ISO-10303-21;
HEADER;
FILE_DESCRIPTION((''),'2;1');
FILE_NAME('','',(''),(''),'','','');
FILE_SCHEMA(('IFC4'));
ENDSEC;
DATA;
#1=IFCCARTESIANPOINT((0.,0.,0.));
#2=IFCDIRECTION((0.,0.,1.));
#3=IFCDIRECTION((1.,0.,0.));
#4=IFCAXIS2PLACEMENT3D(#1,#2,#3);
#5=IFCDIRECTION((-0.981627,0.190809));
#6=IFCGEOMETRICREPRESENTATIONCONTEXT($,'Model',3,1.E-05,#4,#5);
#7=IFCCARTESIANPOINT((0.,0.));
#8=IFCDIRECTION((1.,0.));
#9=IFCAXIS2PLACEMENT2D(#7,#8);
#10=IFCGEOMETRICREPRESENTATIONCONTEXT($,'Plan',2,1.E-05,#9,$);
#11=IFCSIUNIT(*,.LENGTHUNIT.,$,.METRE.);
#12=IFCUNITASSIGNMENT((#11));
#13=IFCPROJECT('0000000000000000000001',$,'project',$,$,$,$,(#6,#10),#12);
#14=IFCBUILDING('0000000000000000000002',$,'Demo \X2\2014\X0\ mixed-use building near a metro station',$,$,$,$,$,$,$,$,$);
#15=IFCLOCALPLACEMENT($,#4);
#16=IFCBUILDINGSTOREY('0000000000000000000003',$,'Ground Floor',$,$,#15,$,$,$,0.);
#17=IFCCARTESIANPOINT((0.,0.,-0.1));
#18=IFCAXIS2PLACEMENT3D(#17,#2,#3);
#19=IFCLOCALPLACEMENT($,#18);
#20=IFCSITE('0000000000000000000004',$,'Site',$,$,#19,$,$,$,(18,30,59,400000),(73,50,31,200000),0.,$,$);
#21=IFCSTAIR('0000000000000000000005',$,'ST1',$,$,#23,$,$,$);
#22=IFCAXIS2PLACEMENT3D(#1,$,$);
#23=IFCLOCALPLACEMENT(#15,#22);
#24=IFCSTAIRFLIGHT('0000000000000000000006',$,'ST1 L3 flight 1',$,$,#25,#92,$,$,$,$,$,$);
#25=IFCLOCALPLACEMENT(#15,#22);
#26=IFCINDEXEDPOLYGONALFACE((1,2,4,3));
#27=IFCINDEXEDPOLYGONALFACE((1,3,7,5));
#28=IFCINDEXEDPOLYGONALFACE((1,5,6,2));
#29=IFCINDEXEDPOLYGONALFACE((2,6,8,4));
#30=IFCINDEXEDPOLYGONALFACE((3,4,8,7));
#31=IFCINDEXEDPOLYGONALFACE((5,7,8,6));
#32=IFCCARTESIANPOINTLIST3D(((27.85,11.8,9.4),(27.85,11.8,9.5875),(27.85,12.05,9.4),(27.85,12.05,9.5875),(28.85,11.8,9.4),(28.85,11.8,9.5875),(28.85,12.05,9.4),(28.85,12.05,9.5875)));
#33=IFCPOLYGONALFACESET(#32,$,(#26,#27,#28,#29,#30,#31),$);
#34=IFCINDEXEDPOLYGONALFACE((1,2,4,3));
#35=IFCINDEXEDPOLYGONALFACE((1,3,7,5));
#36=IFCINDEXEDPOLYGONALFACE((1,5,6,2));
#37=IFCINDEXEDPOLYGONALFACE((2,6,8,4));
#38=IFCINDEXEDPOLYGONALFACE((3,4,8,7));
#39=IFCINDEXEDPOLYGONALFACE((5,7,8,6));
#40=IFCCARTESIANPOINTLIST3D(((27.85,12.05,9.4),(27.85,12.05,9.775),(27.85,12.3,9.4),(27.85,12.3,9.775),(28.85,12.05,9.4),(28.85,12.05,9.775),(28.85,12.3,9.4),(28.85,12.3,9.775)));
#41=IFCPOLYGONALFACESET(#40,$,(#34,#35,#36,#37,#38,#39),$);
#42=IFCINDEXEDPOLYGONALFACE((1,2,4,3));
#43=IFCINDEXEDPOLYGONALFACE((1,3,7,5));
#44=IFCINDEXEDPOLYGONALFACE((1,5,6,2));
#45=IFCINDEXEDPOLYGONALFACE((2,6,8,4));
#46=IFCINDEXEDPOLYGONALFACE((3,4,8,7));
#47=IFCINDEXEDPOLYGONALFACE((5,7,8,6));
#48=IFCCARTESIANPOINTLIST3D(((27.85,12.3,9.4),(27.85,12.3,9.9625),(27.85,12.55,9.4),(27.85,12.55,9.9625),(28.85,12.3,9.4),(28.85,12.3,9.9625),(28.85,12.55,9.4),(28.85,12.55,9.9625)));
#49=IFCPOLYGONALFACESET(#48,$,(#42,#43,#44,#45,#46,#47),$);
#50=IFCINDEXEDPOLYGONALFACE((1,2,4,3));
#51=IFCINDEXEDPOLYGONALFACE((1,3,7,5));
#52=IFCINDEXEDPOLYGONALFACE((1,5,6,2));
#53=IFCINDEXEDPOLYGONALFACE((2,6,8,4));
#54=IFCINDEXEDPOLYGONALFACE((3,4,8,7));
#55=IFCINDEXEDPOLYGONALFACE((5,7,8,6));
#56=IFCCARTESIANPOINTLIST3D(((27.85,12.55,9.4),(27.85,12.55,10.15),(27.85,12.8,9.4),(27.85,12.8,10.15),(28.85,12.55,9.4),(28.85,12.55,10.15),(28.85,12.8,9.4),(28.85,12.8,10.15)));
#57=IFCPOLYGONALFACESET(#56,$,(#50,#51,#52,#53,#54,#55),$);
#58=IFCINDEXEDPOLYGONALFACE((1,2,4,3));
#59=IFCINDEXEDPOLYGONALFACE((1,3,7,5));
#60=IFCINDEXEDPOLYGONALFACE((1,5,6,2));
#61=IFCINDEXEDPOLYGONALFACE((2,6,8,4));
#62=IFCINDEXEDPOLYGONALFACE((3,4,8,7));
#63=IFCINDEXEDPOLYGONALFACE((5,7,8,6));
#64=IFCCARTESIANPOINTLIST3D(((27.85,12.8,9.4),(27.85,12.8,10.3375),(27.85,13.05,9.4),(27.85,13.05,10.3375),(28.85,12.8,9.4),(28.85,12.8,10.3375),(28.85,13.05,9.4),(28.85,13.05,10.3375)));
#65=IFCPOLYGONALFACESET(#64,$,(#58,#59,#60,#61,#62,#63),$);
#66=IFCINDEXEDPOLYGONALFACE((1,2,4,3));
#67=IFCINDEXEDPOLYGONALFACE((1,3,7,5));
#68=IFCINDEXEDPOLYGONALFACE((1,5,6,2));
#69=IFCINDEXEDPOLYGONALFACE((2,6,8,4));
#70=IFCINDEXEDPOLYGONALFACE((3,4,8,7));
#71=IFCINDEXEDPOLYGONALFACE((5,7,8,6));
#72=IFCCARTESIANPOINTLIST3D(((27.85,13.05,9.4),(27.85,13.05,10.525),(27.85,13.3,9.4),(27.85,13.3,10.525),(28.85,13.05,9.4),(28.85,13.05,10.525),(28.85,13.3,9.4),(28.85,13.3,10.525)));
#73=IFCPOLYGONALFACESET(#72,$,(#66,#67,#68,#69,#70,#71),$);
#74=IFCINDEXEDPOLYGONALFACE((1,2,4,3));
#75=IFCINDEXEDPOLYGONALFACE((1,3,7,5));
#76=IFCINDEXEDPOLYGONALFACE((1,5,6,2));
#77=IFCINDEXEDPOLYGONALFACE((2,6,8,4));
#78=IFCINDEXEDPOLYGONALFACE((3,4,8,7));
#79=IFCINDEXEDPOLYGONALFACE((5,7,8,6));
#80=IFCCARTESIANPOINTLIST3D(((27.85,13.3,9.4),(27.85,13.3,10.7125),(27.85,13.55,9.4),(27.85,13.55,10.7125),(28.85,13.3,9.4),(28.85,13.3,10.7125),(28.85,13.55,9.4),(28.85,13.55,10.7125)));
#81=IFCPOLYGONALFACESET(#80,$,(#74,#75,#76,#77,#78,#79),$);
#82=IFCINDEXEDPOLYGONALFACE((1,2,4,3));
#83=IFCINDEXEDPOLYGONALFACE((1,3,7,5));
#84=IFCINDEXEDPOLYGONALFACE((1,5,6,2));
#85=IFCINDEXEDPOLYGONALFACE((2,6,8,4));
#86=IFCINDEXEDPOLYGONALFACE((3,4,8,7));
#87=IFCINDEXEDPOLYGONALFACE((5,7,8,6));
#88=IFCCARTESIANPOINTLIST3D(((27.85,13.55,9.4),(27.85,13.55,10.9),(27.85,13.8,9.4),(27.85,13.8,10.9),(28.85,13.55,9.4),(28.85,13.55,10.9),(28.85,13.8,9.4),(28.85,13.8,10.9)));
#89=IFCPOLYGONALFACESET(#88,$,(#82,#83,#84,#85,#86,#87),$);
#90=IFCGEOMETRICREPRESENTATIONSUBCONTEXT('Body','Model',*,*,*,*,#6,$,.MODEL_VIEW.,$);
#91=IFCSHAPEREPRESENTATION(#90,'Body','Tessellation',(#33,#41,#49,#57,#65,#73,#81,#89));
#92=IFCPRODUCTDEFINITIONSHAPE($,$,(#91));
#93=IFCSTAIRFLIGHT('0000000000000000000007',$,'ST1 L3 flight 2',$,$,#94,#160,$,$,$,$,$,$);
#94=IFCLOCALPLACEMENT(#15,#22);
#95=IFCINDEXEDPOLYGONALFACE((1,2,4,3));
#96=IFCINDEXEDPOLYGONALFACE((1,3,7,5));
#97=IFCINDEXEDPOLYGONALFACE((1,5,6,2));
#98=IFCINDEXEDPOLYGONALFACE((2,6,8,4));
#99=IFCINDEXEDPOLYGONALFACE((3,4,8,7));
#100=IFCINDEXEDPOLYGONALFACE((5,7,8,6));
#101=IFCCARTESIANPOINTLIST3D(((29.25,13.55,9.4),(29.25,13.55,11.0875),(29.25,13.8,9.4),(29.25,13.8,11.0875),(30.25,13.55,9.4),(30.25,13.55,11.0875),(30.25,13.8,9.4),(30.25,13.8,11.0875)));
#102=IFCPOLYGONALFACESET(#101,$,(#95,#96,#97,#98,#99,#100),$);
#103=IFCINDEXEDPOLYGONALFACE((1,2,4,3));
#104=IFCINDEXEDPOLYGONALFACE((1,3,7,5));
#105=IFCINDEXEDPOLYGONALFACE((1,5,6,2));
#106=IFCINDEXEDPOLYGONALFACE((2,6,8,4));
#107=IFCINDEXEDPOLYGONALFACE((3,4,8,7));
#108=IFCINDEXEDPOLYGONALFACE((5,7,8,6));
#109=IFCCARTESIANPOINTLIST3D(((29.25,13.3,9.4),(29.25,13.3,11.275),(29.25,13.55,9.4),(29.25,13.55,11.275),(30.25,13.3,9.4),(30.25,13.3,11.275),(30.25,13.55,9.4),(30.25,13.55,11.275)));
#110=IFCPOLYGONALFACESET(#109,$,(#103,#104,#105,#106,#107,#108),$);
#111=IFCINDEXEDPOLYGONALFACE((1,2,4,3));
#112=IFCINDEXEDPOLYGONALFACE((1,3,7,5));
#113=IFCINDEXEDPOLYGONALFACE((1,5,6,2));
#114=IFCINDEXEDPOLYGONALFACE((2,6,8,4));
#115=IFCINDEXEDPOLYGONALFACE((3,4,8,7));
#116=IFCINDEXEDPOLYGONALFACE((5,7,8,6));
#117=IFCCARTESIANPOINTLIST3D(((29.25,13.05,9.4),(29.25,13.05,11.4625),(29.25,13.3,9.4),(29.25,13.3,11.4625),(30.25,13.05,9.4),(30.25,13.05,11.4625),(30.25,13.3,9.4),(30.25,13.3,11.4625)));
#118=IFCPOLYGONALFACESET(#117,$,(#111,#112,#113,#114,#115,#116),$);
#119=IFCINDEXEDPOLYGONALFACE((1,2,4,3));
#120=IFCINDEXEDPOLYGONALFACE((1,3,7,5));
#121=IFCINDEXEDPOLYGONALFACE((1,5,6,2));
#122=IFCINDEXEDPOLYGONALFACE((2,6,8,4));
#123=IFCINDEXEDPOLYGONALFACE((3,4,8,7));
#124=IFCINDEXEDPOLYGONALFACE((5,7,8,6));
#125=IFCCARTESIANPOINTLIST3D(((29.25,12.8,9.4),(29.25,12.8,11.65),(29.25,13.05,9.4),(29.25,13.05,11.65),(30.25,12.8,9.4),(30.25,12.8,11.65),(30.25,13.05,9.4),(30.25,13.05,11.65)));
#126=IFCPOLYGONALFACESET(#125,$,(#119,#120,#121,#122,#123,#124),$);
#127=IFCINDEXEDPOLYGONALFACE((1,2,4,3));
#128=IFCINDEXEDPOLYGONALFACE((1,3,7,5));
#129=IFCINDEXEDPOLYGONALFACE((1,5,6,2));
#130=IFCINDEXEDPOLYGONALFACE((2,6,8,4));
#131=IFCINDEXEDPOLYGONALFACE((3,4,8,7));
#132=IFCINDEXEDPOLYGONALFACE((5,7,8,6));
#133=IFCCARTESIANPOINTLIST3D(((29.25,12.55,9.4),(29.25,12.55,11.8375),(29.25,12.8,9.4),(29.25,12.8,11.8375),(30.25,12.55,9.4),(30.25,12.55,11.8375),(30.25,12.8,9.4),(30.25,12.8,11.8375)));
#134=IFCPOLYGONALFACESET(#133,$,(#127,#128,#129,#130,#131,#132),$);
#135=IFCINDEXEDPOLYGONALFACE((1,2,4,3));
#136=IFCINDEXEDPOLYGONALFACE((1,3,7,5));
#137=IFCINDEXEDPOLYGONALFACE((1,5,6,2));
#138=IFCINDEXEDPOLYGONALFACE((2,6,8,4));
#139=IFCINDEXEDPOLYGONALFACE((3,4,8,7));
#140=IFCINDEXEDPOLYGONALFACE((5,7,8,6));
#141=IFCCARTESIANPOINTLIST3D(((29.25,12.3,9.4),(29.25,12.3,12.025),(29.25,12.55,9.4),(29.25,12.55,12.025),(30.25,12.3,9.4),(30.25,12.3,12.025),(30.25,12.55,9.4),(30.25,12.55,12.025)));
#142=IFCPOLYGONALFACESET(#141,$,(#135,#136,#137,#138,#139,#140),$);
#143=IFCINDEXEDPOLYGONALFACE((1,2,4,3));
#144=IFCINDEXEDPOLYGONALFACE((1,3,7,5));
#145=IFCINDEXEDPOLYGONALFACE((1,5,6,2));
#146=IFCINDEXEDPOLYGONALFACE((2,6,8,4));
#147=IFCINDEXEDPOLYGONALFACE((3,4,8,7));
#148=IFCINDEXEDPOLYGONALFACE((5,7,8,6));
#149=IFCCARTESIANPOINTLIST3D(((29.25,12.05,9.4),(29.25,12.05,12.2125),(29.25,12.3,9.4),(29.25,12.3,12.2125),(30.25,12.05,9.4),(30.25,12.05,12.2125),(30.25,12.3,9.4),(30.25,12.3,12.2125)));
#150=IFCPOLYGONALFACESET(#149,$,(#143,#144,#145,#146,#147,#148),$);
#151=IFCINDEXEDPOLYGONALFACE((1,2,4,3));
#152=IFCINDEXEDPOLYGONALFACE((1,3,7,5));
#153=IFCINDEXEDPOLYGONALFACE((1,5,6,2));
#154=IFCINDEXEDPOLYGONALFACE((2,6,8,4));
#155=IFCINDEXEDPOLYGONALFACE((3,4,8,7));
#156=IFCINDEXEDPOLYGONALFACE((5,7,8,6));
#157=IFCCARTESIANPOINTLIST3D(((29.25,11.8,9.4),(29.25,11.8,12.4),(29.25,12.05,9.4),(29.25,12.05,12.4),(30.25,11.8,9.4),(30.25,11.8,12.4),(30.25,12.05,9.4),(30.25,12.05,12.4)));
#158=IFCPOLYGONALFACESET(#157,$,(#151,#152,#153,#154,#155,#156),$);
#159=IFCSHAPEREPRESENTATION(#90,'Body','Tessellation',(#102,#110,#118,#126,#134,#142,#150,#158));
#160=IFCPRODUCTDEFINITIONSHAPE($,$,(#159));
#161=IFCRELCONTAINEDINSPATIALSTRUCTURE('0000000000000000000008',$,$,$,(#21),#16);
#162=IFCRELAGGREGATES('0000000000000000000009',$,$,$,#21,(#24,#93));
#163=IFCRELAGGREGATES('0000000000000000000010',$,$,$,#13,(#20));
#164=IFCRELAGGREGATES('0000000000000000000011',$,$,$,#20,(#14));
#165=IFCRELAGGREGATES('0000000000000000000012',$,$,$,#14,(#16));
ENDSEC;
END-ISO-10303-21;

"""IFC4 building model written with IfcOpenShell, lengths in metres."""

from ifc_helpers import new_model, si_unit, direction, frame, origin_with_axes, origin_2d_with_axis, place, context, subcontext, project, spatial, line, indexed_curve, outline, extrude, element, aggregate, save


model = new_model("IFC4")

# Units and contexts
model_context = context("Model", 3, precision=1e-05, world=origin_with_axes(), true_north=direction((-0.981627, 0.190809)))
plan_context = context("Plan", 2, precision=1e-05, world=origin_2d_with_axis())
body_context = subcontext(model_context, "Body", "Model", "MODEL_VIEW")
ifc_project = project(units=[si_unit("LENGTHUNIT", "METRE")], contexts=[model_context, plan_context])

# Site, building, storey
site_placement = place(None, frame((0.0, 0.0, -0.1), z_axis=(0.0, 0.0, 1.0), x_axis=(1.0, 0.0, 0.0)))
site = spatial("IfcSite", under=ifc_project, at=site_placement, Name="Site", RefLatitude=(18, 30, 59, 400000), RefLongitude=(73, 50, 31, 200000), RefElevation=0.0)
building = spatial("IfcBuilding", under=site, Name="Demo — mixed-use building near a metro station")
storey_placement = place(None, origin_with_axes())
storey = spatial("IfcBuildingStorey", under=building, at=storey_placement, Name="Ground Floor", Elevation=0.0)

# Stair, stair flights
stair = element("IfcStair", 1, inside=storey, Name="ST1")
stair_flight_1_placement = place(None, origin_with_axes())
stair_flight_1 = element("IfcStairFlight", 2, at=stair_flight_1_placement, Name="ST1 L3 flight 1", context=body_context, shape_type="SweptSolid", body=[
    extrude(outline(indexed_curve([(27.85, 11.8), (28.85, 11.8), (28.85, 12.05), (27.85, 12.05)], segments=[line(1, 2, 3, 4, 1)])), frame((0.0, 0.0, 9.4), z_axis=(0.0, 0.0, 1.0), x_axis=(1.0, 0.0, 0.0)), (0.0, 0.0, 1.0), 0.1875),
    extrude(outline(indexed_curve([(27.85, 12.05), (28.85, 12.05), (28.85, 12.3), (27.85, 12.3)], segments=[line(1, 2, 3, 4, 1)])), frame((0.0, 0.0, 9.4), z_axis=(0.0, 0.0, 1.0), x_axis=(1.0, 0.0, 0.0)), (0.0, 0.0, 1.0), 0.375),
    extrude(outline(indexed_curve([(27.85, 12.3), (28.85, 12.3), (28.85, 12.55), (27.85, 12.55)], segments=[line(1, 2, 3, 4, 1)])), frame((0.0, 0.0, 9.4), z_axis=(0.0, 0.0, 1.0), x_axis=(1.0, 0.0, 0.0)), (0.0, 0.0, 1.0), 0.5625),
    extrude(outline(indexed_curve([(27.85, 12.55), (28.85, 12.55), (28.85, 12.8), (27.85, 12.8)], segments=[line(1, 2, 3, 4, 1)])), frame((0.0, 0.0, 9.4), z_axis=(0.0, 0.0, 1.0), x_axis=(1.0, 0.0, 0.0)), (0.0, 0.0, 1.0), 0.75),
    extrude(outline(indexed_curve([(27.85, 12.8), (28.85, 12.8), (28.85, 13.05), (27.85, 13.05)], segments=[line(1, 2, 3, 4, 1)])), frame((0.0, 0.0, 9.4), z_axis=(0.0, 0.0, 1.0), x_axis=(1.0, 0.0, 0.0)), (0.0, 0.0, 1.0), 0.9375),
    extrude(outline(indexed_curve([(27.85, 13.05), (28.85, 13.05), (28.85, 13.3), (27.85, 13.3)], segments=[line(1, 2, 3, 4, 1)])), frame((0.0, 0.0, 9.4), z_axis=(0.0, 0.0, 1.0), x_axis=(1.0, 0.0, 0.0)), (0.0, 0.0, 1.0), 1.125),
    extrude(outline(indexed_curve([(27.85, 13.3), (28.85, 13.3), (28.85, 13.55), (27.85, 13.55)], segments=[line(1, 2, 3, 4, 1)])), frame((0.0, 0.0, 9.4), z_axis=(0.0, 0.0, 1.0), x_axis=(1.0, 0.0, 0.0)), (0.0, 0.0, 1.0), 1.3125),
    extrude(outline(indexed_curve([(27.85, 13.55), (28.85, 13.55), (28.85, 13.8), (27.85, 13.8)], segments=[line(1, 2, 3, 4, 1)])), frame((0.0, 0.0, 9.4), z_axis=(0.0, 0.0, 1.0), x_axis=(1.0, 0.0, 0.0)), (0.0, 0.0, 1.0), 1.5),
])
stair_flight_2_placement = place(None, origin_with_axes())
stair_flight_2 = element("IfcStairFlight", 3, at=stair_flight_2_placement, Name="ST1 L3 flight 2", context=body_context, shape_type="SweptSolid", body=[
    extrude(outline(indexed_curve([(29.25, 13.55), (30.25, 13.55), (30.25, 13.8), (29.25, 13.8)], segments=[line(1, 2, 3, 4, 1)])), frame((0.0, 0.0, 9.4), z_axis=(0.0, 0.0, 1.0), x_axis=(1.0, 0.0, 0.0)), (0.0, 0.0, 1.0), 1.6875),
    extrude(outline(indexed_curve([(29.25, 13.3), (30.25, 13.3), (30.25, 13.55), (29.25, 13.55)], segments=[line(1, 2, 3, 4, 1)])), frame((0.0, 0.0, 9.4), z_axis=(0.0, 0.0, 1.0), x_axis=(1.0, 0.0, 0.0)), (0.0, 0.0, 1.0), 1.875),
    extrude(outline(indexed_curve([(29.25, 13.05), (30.25, 13.05), (30.25, 13.3), (29.25, 13.3)], segments=[line(1, 2, 3, 4, 1)])), frame((0.0, 0.0, 9.4), z_axis=(0.0, 0.0, 1.0), x_axis=(1.0, 0.0, 0.0)), (0.0, 0.0, 1.0), 2.0625),
    extrude(outline(indexed_curve([(29.25, 12.8), (30.25, 12.8), (30.25, 13.05), (29.25, 13.05)], segments=[line(1, 2, 3, 4, 1)])), frame((0.0, 0.0, 9.4), z_axis=(0.0, 0.0, 1.0), x_axis=(1.0, 0.0, 0.0)), (0.0, 0.0, 1.0), 2.25),
    extrude(outline(indexed_curve([(29.25, 12.55), (30.25, 12.55), (30.25, 12.8), (29.25, 12.8)], segments=[line(1, 2, 3, 4, 1)])), frame((0.0, 0.0, 9.4), z_axis=(0.0, 0.0, 1.0), x_axis=(1.0, 0.0, 0.0)), (0.0, 0.0, 1.0), 2.4375),
    extrude(outline(indexed_curve([(29.25, 12.3), (30.25, 12.3), (30.25, 12.55), (29.25, 12.55)], segments=[line(1, 2, 3, 4, 1)])), frame((0.0, 0.0, 9.4), z_axis=(0.0, 0.0, 1.0), x_axis=(1.0, 0.0, 0.0)), (0.0, 0.0, 1.0), 2.625),
    extrude(outline(indexed_curve([(29.25, 12.05), (30.25, 12.05), (30.25, 12.3), (29.25, 12.3)], segments=[line(1, 2, 3, 4, 1)])), frame((0.0, 0.0, 9.4), z_axis=(0.0, 0.0, 1.0), x_axis=(1.0, 0.0, 0.0)), (0.0, 0.0, 1.0), 2.8125),
    extrude(outline(indexed_curve([(29.25, 11.8), (30.25, 11.8), (30.25, 12.05), (29.25, 12.05)], segments=[line(1, 2, 3, 4, 1)])), frame((0.0, 0.0, 9.4), z_axis=(0.0, 0.0, 1.0), x_axis=(1.0, 0.0, 0.0)), (0.0, 0.0, 1.0), 3.0),
])
aggregate(stair, [stair_flight_1, stair_flight_2])

save(model, "model.ifc")
